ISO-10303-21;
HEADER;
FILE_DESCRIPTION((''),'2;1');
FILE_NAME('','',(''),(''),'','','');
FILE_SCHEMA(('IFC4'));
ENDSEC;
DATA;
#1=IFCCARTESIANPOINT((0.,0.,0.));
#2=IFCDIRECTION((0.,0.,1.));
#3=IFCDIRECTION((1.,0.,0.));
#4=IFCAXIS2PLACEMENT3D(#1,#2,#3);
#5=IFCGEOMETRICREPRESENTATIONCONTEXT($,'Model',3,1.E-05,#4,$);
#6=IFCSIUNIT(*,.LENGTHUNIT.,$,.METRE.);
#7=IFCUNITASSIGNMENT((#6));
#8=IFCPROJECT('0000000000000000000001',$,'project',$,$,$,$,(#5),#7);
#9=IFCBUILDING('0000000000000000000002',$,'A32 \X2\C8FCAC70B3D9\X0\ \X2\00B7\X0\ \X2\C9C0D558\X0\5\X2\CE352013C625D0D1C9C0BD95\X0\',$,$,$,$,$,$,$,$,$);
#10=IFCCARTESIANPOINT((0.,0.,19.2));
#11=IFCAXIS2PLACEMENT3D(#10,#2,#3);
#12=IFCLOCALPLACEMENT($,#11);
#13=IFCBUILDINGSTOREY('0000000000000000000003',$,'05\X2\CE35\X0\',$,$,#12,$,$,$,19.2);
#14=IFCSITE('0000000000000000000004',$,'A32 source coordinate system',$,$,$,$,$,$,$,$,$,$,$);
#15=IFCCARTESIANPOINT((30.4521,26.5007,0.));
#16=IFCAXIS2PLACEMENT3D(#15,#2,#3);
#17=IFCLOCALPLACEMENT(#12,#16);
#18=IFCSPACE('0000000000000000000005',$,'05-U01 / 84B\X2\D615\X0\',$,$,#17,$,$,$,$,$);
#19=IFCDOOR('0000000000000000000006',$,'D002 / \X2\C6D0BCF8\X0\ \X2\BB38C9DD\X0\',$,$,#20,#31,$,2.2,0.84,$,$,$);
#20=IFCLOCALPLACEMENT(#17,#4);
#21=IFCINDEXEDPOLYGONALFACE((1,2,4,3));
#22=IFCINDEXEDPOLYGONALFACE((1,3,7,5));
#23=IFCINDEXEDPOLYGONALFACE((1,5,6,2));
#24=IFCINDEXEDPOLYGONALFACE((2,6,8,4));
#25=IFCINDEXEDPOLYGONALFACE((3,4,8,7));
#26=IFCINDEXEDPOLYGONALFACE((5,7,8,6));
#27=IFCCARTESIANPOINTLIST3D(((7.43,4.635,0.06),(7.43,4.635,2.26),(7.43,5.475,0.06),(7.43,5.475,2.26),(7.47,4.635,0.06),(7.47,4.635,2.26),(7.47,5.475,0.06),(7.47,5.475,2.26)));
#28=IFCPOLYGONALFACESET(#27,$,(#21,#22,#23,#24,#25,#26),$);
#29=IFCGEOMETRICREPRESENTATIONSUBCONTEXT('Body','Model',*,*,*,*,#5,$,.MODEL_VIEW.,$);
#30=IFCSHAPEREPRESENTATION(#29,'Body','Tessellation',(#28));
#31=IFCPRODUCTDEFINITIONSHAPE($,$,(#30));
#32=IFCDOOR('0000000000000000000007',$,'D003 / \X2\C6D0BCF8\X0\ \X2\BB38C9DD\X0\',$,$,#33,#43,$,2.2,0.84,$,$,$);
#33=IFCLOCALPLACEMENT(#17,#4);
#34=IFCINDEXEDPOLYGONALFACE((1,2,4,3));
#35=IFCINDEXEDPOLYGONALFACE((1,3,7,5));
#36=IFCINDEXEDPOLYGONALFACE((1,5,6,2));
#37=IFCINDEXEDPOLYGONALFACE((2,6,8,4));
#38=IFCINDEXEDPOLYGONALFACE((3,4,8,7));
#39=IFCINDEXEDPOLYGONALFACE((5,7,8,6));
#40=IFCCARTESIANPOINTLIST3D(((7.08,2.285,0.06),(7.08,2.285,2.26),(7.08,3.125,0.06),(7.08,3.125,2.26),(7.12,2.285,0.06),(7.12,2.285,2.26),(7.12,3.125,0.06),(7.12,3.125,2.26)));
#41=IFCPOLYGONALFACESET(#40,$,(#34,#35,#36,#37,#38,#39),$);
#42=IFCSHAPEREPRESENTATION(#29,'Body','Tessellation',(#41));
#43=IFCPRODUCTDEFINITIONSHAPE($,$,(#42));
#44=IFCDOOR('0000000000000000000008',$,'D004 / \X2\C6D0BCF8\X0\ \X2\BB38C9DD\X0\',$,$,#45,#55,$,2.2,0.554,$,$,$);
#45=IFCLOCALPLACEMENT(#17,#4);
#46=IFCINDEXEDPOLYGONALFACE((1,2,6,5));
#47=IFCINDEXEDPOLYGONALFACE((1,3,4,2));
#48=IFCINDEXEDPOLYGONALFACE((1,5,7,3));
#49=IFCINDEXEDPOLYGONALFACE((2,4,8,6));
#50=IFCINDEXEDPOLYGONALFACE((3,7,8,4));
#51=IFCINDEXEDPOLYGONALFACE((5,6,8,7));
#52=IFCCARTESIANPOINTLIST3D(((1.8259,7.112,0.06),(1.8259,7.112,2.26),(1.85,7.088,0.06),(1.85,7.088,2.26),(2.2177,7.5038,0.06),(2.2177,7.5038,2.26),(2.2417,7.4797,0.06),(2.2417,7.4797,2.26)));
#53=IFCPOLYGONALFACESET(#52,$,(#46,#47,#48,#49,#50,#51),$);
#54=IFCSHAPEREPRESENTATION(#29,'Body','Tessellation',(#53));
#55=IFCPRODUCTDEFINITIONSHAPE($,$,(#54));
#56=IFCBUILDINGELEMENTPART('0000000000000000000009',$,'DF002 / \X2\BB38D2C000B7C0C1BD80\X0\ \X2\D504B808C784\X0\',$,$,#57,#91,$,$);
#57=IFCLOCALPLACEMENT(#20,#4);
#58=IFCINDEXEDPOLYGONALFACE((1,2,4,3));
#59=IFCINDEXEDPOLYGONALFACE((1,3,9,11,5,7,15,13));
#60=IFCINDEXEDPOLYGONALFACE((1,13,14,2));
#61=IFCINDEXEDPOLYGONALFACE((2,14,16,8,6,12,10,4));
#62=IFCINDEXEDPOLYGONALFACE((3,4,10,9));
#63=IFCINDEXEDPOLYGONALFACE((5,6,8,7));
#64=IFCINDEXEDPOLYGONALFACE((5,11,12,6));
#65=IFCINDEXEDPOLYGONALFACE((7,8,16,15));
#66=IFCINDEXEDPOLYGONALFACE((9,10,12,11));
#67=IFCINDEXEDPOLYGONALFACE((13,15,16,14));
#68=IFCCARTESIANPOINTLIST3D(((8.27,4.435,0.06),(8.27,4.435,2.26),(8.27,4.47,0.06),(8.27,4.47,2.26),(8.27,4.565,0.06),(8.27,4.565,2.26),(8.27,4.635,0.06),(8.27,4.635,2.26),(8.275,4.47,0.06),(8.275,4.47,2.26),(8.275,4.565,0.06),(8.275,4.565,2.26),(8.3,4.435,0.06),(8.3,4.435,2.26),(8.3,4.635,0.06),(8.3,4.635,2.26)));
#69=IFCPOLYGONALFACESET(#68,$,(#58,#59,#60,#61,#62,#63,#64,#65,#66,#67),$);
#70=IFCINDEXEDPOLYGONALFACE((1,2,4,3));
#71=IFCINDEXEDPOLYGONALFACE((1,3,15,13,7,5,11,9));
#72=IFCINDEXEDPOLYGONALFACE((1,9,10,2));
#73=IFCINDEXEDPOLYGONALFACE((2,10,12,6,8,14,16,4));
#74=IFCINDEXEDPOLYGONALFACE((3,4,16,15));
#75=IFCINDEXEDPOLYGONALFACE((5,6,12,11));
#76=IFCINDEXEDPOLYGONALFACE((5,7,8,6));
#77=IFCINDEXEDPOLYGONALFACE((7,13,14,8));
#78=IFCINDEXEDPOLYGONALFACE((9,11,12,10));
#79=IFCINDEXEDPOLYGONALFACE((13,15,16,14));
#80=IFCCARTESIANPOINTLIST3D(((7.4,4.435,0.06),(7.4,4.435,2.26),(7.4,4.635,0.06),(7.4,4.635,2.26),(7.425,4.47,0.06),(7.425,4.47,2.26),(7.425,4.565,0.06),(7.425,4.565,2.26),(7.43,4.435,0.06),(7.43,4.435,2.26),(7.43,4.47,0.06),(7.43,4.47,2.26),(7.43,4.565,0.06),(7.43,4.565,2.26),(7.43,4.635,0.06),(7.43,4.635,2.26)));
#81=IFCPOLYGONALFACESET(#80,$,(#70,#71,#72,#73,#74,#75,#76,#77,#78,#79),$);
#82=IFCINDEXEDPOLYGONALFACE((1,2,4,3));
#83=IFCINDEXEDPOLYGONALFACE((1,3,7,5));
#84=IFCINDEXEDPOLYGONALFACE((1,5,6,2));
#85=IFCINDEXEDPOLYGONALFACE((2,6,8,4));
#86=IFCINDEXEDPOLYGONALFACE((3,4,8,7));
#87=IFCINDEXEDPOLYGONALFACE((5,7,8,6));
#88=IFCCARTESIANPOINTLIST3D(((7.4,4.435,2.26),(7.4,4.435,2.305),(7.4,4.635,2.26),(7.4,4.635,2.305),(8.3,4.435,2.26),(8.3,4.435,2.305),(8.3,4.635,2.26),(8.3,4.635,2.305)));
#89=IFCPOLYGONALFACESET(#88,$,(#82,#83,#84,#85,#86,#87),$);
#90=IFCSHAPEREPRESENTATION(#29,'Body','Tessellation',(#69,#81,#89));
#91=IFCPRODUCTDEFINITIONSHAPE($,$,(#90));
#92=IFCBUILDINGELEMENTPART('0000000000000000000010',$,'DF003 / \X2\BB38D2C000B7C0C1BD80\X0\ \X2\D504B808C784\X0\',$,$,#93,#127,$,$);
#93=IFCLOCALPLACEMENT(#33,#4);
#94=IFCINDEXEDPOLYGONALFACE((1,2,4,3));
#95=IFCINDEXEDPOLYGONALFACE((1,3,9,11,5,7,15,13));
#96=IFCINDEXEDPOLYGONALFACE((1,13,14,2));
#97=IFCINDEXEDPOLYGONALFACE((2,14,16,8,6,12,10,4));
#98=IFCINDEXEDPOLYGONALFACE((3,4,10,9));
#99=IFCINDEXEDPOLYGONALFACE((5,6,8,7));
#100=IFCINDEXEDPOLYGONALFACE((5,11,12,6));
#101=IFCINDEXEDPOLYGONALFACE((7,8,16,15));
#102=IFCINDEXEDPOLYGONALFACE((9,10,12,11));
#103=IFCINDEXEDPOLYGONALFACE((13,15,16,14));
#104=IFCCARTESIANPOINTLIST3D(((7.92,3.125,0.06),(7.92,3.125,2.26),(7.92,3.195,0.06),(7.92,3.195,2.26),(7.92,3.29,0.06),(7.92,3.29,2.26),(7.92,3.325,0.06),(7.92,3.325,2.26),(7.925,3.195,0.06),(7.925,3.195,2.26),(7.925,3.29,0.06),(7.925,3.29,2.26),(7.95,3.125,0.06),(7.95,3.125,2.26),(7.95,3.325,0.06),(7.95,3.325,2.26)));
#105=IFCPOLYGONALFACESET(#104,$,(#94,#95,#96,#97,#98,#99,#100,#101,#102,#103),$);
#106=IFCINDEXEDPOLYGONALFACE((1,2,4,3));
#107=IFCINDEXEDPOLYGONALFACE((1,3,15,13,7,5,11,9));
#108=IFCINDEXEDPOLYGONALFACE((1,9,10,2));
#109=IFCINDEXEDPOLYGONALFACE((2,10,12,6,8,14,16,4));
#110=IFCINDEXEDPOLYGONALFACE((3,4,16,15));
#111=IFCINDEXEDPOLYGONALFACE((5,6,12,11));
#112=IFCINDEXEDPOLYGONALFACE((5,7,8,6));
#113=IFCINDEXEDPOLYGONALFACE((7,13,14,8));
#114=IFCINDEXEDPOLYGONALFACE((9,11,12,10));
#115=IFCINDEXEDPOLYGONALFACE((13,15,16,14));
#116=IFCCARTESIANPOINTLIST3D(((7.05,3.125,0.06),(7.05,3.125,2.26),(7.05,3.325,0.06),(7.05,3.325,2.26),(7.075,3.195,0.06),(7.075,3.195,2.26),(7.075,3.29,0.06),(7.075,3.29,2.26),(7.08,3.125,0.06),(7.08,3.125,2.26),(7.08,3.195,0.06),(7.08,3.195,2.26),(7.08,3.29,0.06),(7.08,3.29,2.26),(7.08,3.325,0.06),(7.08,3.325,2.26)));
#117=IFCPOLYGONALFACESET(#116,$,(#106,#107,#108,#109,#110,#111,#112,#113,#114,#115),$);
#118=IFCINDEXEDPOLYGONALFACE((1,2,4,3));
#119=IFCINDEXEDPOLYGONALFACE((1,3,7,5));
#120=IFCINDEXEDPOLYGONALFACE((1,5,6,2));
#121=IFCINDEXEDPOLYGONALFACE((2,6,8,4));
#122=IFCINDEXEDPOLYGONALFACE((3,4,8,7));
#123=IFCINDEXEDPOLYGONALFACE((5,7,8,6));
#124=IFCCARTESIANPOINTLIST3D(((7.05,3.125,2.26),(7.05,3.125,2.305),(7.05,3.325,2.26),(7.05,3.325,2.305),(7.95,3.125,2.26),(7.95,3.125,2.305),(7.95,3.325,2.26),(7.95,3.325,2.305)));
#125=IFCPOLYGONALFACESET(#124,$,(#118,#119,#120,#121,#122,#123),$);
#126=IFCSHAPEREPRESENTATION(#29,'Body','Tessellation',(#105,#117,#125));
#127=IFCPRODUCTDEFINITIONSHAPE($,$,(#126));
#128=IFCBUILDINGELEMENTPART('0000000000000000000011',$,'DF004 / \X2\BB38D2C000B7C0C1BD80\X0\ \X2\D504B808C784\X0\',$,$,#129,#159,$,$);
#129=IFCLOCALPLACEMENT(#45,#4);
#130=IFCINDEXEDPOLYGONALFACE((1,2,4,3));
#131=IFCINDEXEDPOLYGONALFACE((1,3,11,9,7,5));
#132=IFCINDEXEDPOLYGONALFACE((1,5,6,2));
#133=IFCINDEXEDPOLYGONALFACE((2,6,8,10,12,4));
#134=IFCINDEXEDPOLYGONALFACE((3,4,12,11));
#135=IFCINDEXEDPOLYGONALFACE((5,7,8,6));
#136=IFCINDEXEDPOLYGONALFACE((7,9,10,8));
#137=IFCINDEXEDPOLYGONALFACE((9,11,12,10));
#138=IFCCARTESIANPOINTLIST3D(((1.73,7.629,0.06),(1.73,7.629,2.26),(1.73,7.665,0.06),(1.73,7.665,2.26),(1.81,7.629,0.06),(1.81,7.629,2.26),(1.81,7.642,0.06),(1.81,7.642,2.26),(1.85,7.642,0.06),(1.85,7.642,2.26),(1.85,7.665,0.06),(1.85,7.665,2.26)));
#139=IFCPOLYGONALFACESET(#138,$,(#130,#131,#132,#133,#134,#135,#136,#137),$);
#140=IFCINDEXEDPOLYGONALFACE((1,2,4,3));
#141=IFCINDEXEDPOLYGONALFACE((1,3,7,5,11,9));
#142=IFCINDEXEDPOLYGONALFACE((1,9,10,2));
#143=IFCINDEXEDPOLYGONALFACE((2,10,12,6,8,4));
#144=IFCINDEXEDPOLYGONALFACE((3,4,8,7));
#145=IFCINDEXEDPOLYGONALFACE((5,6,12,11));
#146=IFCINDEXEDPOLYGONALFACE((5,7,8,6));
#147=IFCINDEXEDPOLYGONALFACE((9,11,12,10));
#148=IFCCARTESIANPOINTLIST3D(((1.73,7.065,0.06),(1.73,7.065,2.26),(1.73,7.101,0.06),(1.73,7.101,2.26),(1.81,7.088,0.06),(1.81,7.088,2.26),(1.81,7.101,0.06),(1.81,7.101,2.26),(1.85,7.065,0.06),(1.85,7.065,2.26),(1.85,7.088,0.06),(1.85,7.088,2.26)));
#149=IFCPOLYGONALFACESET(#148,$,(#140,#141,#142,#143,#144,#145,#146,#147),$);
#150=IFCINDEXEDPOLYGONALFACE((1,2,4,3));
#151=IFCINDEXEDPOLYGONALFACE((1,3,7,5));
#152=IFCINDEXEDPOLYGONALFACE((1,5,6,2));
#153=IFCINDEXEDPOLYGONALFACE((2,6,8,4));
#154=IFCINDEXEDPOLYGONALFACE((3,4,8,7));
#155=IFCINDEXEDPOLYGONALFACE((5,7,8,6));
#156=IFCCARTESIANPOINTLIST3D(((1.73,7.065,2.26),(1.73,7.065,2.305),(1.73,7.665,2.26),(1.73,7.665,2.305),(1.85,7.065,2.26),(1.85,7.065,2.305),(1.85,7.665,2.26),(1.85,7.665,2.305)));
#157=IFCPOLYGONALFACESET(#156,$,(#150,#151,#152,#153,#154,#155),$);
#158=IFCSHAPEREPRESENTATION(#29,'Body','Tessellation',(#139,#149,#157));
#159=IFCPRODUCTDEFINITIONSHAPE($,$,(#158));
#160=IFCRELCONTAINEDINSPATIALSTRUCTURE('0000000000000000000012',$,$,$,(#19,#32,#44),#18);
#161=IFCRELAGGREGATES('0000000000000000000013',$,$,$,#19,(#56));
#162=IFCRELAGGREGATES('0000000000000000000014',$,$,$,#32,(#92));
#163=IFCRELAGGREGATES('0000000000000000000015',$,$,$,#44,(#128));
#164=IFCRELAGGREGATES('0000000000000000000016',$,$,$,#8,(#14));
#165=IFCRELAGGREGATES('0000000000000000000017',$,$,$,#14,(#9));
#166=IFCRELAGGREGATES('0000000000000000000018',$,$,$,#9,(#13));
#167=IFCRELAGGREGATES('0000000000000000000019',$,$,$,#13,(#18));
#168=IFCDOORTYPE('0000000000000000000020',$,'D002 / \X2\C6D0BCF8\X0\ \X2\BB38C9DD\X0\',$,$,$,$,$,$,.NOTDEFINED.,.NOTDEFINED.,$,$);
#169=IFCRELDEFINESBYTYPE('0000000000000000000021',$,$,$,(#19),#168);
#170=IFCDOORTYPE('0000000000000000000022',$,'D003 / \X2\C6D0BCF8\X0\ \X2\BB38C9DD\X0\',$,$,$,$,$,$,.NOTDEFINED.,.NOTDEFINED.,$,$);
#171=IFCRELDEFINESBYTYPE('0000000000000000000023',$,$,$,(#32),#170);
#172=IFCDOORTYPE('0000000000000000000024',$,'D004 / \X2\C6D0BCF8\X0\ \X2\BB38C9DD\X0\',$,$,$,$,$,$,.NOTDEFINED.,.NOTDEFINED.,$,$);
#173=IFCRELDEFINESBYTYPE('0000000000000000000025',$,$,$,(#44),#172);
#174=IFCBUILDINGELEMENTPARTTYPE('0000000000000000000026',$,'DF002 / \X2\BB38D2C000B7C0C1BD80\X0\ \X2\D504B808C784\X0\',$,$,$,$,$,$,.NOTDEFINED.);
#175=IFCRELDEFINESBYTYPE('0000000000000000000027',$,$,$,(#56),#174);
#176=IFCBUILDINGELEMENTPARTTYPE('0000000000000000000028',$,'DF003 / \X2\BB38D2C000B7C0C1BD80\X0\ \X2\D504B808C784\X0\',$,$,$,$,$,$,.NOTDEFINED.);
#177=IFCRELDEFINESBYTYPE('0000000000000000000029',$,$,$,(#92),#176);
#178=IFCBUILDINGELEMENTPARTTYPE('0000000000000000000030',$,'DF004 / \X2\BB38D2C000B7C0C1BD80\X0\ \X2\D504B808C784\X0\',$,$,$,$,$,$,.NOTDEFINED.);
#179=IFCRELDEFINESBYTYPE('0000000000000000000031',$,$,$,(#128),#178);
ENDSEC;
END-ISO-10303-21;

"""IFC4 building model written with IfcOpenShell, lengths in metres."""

from ifc_helpers import new_model, si_unit, frame, origin, origin_with_axes, place, context, subcontext, project, spatial, polyline, outline, extrude, source, transform, mapped, type_object, type_shapes, element, aggregate, save


model = new_model("IFC4")

# Units and contexts
model_context = context("Model", 3, precision=1e-05, world=origin_with_axes())
body_context = subcontext(model_context, "Body", "Model", "MODEL_VIEW")
ifc_project = project(units=[si_unit("LENGTHUNIT", "METRE")], contexts=[model_context])

# Site, building, storey, space
storey_placement = place(None, frame((0.0, 0.0, 19.2), z_axis=(0.0, 0.0, 1.0), x_axis=(1.0, 0.0, 0.0)))
space_placement = place(storey_placement, frame((30.4521, 26.5007, 0.0), z_axis=(0.0, 0.0, 1.0), x_axis=(1.0, 0.0, 0.0)))
site = spatial("IfcSite", under=ifc_project, Name="A32 source coordinate system")
building = spatial("IfcBuilding", under=site, Name="A32 주거동 · 지하5층–옥탑지붕")
storey = spatial("IfcBuildingStorey", under=building, at=storey_placement, Name="05층", Elevation=19.2)
space = spatial("IfcSpace", under=storey, at=space_placement, Name="05-U01 / 84B형")

# Doors
door_type_1 = type_object("IfcDoorType", Name="D002 / 원본 문짝", OperationType="NOTDEFINED", PredefinedType="NOTDEFINED")
shared_shape_1 = source(origin(), body_context, "Body", "SweptSolid", [
    extrude(outline(polyline([(7.43, 4.635), (7.43, 5.475), (7.47, 5.475), (7.47, 4.635), (7.43, 4.635)])), frame((0.0, 0.0, 0.06)), (0.0, 0.0, 1.0), 2.2),
])
type_shapes(door_type_1, [shared_shape_1])
door_1_placement = place(space_placement, origin_with_axes())
door_1 = element("IfcDoor", 1, at=door_1_placement, inside=space, type_object=door_type_1, Name="D002 / 원본 문짝", OverallHeight=2.2, OverallWidth=0.84, context=body_context, shape_type="MappedRepresentation", body=[
    mapped(shared_shape_1, transform((0.0, 0.0, 0.0), scale=1.0)),
])
door_type_2 = type_object("IfcDoorType", Name="D003 / 원본 문짝", OperationType="NOTDEFINED", PredefinedType="NOTDEFINED")
shared_shape_2 = source(origin(), body_context, "Body", "SweptSolid", [
    extrude(outline(polyline([(7.12, 2.285), (7.08, 2.285), (7.08, 3.125), (7.12, 3.125), (7.12, 2.285)])), frame((0.0, 0.0, 0.06)), (0.0, 0.0, 1.0), 2.2),
])
type_shapes(door_type_2, [shared_shape_2])
door_2_placement = place(space_placement, origin_with_axes())
door_2 = element("IfcDoor", 2, at=door_2_placement, inside=space, type_object=door_type_2, Name="D003 / 원본 문짝", OverallHeight=2.2, OverallWidth=0.84, context=body_context, shape_type="MappedRepresentation", body=[
    mapped(shared_shape_2, transform((0.0, 0.0, 0.0), scale=1.0)),
])
door_type_3 = type_object("IfcDoorType", Name="D004 / 원본 문짝", OperationType="NOTDEFINED", PredefinedType="NOTDEFINED")
shared_shape_3 = source(origin(), body_context, "Body", "SweptSolid", [
    extrude(outline(polyline([(2.2177, 7.5038), (2.2417, 7.4797), (1.85, 7.088), (1.8259, 7.112), (2.2177, 7.5038)])), frame((0.0, 0.0, 0.06)), (0.0, 0.0, 1.0), 2.2),
])
type_shapes(door_type_3, [shared_shape_3])
door_3_placement = place(space_placement, origin_with_axes())
door_3 = element("IfcDoor", 3, at=door_3_placement, inside=space, type_object=door_type_3, Name="D004 / 원본 문짝", OverallHeight=2.2, OverallWidth=0.554, context=body_context, shape_type="MappedRepresentation", body=[
    mapped(shared_shape_3, transform((0.0, 0.0, 0.0), scale=1.0)),
])

# Building element parts
building_element_part_type_1 = type_object("IfcBuildingElementPartType", Name="DF002 / 문틀·상부 프레임", PredefinedType="NOTDEFINED")
shared_shape_4 = source(origin(), body_context, "Body", "SweptSolid", [
    extrude(outline(polyline([(8.3, 4.435), (8.27, 4.435), (8.27, 4.47), (8.275, 4.47), (8.275, 4.565), (8.27, 4.565), (8.27, 4.635), (8.3, 4.635), (8.3, 4.435)])), frame((0.0, 0.0, 0.06)), (0.0, 0.0, 1.0), 2.2),
    extrude(outline(polyline([(7.43, 4.635), (7.43, 4.565), (7.425, 4.565), (7.425, 4.47), (7.43, 4.47), (7.43, 4.435), (7.4, 4.435), (7.4, 4.635), (7.43, 4.635)])), frame((0.0, 0.0, 0.06)), (0.0, 0.0, 1.0), 2.2),
    extrude(outline(polyline([(7.4, 4.435), (7.4, 4.635), (8.3, 4.635), (8.3, 4.435), (7.4, 4.435)])), frame((0.0, 0.0, 2.26)), (0.0, 0.0, 1.0), 0.045),
])
type_shapes(building_element_part_type_1, [shared_shape_4])
building_element_part_1_placement = place(door_1_placement, origin_with_axes())
building_element_part_1 = element("IfcBuildingElementPart", 4, at=building_element_part_1_placement, type_object=building_element_part_type_1, Name="DF002 / 문틀·상부 프레임", context=body_context, shape_type="MappedRepresentation", body=[
    mapped(shared_shape_4, transform((0.0, 0.0, 0.0), scale=1.0)),
])
aggregate(door_1, [building_element_part_1])
building_element_part_type_2 = type_object("IfcBuildingElementPartType", Name="DF003 / 문틀·상부 프레임", PredefinedType="NOTDEFINED")
shared_shape_5 = source(origin(), body_context, "Body", "SweptSolid", [
    extrude(outline(polyline([(7.92, 3.125), (7.92, 3.195), (7.925, 3.195), (7.925, 3.29), (7.92, 3.29), (7.92, 3.325), (7.95, 3.325), (7.95, 3.125), (7.92, 3.125)])), frame((0.0, 0.0, 0.06)), (0.0, 0.0, 1.0), 2.2),
    extrude(outline(polyline([(7.05, 3.325), (7.08, 3.325), (7.08, 3.29), (7.075, 3.29), (7.075, 3.195), (7.08, 3.195), (7.08, 3.125), (7.05, 3.125), (7.05, 3.325)])), frame((0.0, 0.0, 0.06)), (0.0, 0.0, 1.0), 2.2),
    extrude(outline(polyline([(7.05, 3.125), (7.05, 3.325), (7.95, 3.325), (7.95, 3.125), (7.05, 3.125)])), frame((0.0, 0.0, 2.26)), (0.0, 0.0, 1.0), 0.045),
])
type_shapes(building_element_part_type_2, [shared_shape_5])
building_element_part_2_placement = place(door_2_placement, origin_with_axes())
building_element_part_2 = element("IfcBuildingElementPart", 5, at=building_element_part_2_placement, type_object=building_element_part_type_2, Name="DF003 / 문틀·상부 프레임", context=body_context, shape_type="MappedRepresentation", body=[
    mapped(shared_shape_5, transform((0.0, 0.0, 0.0), scale=1.0)),
])
aggregate(door_2, [building_element_part_2])
building_element_part_type_3 = type_object("IfcBuildingElementPartType", Name="DF004 / 문틀·상부 프레임", PredefinedType="NOTDEFINED")
shared_shape_6 = source(origin(), body_context, "Body", "SweptSolid", [
    extrude(outline(polyline([(1.85, 7.665), (1.85, 7.642), (1.81, 7.642), (1.81, 7.629), (1.73, 7.629), (1.73, 7.665), (1.85, 7.665)])), frame((0.0, 0.0, 0.06)), (0.0, 0.0, 1.0), 2.2),
    extrude(outline(polyline([(1.73, 7.101), (1.81, 7.101), (1.81, 7.088), (1.85, 7.088), (1.85, 7.065), (1.73, 7.065), (1.73, 7.101)])), frame((0.0, 0.0, 0.06)), (0.0, 0.0, 1.0), 2.2),
    extrude(outline(polyline([(1.73, 7.065), (1.73, 7.665), (1.85, 7.665), (1.85, 7.065), (1.73, 7.065)])), frame((0.0, 0.0, 2.26)), (0.0, 0.0, 1.0), 0.045),
])
type_shapes(building_element_part_type_3, [shared_shape_6])
building_element_part_3_placement = place(door_3_placement, origin_with_axes())
building_element_part_3 = element("IfcBuildingElementPart", 6, at=building_element_part_3_placement, type_object=building_element_part_type_3, Name="DF004 / 문틀·상부 프레임", context=body_context, shape_type="MappedRepresentation", body=[
    mapped(shared_shape_6, transform((0.0, 0.0, 0.0), scale=1.0)),
])
aggregate(door_3, [building_element_part_3])

save(model, "model.ifc")
